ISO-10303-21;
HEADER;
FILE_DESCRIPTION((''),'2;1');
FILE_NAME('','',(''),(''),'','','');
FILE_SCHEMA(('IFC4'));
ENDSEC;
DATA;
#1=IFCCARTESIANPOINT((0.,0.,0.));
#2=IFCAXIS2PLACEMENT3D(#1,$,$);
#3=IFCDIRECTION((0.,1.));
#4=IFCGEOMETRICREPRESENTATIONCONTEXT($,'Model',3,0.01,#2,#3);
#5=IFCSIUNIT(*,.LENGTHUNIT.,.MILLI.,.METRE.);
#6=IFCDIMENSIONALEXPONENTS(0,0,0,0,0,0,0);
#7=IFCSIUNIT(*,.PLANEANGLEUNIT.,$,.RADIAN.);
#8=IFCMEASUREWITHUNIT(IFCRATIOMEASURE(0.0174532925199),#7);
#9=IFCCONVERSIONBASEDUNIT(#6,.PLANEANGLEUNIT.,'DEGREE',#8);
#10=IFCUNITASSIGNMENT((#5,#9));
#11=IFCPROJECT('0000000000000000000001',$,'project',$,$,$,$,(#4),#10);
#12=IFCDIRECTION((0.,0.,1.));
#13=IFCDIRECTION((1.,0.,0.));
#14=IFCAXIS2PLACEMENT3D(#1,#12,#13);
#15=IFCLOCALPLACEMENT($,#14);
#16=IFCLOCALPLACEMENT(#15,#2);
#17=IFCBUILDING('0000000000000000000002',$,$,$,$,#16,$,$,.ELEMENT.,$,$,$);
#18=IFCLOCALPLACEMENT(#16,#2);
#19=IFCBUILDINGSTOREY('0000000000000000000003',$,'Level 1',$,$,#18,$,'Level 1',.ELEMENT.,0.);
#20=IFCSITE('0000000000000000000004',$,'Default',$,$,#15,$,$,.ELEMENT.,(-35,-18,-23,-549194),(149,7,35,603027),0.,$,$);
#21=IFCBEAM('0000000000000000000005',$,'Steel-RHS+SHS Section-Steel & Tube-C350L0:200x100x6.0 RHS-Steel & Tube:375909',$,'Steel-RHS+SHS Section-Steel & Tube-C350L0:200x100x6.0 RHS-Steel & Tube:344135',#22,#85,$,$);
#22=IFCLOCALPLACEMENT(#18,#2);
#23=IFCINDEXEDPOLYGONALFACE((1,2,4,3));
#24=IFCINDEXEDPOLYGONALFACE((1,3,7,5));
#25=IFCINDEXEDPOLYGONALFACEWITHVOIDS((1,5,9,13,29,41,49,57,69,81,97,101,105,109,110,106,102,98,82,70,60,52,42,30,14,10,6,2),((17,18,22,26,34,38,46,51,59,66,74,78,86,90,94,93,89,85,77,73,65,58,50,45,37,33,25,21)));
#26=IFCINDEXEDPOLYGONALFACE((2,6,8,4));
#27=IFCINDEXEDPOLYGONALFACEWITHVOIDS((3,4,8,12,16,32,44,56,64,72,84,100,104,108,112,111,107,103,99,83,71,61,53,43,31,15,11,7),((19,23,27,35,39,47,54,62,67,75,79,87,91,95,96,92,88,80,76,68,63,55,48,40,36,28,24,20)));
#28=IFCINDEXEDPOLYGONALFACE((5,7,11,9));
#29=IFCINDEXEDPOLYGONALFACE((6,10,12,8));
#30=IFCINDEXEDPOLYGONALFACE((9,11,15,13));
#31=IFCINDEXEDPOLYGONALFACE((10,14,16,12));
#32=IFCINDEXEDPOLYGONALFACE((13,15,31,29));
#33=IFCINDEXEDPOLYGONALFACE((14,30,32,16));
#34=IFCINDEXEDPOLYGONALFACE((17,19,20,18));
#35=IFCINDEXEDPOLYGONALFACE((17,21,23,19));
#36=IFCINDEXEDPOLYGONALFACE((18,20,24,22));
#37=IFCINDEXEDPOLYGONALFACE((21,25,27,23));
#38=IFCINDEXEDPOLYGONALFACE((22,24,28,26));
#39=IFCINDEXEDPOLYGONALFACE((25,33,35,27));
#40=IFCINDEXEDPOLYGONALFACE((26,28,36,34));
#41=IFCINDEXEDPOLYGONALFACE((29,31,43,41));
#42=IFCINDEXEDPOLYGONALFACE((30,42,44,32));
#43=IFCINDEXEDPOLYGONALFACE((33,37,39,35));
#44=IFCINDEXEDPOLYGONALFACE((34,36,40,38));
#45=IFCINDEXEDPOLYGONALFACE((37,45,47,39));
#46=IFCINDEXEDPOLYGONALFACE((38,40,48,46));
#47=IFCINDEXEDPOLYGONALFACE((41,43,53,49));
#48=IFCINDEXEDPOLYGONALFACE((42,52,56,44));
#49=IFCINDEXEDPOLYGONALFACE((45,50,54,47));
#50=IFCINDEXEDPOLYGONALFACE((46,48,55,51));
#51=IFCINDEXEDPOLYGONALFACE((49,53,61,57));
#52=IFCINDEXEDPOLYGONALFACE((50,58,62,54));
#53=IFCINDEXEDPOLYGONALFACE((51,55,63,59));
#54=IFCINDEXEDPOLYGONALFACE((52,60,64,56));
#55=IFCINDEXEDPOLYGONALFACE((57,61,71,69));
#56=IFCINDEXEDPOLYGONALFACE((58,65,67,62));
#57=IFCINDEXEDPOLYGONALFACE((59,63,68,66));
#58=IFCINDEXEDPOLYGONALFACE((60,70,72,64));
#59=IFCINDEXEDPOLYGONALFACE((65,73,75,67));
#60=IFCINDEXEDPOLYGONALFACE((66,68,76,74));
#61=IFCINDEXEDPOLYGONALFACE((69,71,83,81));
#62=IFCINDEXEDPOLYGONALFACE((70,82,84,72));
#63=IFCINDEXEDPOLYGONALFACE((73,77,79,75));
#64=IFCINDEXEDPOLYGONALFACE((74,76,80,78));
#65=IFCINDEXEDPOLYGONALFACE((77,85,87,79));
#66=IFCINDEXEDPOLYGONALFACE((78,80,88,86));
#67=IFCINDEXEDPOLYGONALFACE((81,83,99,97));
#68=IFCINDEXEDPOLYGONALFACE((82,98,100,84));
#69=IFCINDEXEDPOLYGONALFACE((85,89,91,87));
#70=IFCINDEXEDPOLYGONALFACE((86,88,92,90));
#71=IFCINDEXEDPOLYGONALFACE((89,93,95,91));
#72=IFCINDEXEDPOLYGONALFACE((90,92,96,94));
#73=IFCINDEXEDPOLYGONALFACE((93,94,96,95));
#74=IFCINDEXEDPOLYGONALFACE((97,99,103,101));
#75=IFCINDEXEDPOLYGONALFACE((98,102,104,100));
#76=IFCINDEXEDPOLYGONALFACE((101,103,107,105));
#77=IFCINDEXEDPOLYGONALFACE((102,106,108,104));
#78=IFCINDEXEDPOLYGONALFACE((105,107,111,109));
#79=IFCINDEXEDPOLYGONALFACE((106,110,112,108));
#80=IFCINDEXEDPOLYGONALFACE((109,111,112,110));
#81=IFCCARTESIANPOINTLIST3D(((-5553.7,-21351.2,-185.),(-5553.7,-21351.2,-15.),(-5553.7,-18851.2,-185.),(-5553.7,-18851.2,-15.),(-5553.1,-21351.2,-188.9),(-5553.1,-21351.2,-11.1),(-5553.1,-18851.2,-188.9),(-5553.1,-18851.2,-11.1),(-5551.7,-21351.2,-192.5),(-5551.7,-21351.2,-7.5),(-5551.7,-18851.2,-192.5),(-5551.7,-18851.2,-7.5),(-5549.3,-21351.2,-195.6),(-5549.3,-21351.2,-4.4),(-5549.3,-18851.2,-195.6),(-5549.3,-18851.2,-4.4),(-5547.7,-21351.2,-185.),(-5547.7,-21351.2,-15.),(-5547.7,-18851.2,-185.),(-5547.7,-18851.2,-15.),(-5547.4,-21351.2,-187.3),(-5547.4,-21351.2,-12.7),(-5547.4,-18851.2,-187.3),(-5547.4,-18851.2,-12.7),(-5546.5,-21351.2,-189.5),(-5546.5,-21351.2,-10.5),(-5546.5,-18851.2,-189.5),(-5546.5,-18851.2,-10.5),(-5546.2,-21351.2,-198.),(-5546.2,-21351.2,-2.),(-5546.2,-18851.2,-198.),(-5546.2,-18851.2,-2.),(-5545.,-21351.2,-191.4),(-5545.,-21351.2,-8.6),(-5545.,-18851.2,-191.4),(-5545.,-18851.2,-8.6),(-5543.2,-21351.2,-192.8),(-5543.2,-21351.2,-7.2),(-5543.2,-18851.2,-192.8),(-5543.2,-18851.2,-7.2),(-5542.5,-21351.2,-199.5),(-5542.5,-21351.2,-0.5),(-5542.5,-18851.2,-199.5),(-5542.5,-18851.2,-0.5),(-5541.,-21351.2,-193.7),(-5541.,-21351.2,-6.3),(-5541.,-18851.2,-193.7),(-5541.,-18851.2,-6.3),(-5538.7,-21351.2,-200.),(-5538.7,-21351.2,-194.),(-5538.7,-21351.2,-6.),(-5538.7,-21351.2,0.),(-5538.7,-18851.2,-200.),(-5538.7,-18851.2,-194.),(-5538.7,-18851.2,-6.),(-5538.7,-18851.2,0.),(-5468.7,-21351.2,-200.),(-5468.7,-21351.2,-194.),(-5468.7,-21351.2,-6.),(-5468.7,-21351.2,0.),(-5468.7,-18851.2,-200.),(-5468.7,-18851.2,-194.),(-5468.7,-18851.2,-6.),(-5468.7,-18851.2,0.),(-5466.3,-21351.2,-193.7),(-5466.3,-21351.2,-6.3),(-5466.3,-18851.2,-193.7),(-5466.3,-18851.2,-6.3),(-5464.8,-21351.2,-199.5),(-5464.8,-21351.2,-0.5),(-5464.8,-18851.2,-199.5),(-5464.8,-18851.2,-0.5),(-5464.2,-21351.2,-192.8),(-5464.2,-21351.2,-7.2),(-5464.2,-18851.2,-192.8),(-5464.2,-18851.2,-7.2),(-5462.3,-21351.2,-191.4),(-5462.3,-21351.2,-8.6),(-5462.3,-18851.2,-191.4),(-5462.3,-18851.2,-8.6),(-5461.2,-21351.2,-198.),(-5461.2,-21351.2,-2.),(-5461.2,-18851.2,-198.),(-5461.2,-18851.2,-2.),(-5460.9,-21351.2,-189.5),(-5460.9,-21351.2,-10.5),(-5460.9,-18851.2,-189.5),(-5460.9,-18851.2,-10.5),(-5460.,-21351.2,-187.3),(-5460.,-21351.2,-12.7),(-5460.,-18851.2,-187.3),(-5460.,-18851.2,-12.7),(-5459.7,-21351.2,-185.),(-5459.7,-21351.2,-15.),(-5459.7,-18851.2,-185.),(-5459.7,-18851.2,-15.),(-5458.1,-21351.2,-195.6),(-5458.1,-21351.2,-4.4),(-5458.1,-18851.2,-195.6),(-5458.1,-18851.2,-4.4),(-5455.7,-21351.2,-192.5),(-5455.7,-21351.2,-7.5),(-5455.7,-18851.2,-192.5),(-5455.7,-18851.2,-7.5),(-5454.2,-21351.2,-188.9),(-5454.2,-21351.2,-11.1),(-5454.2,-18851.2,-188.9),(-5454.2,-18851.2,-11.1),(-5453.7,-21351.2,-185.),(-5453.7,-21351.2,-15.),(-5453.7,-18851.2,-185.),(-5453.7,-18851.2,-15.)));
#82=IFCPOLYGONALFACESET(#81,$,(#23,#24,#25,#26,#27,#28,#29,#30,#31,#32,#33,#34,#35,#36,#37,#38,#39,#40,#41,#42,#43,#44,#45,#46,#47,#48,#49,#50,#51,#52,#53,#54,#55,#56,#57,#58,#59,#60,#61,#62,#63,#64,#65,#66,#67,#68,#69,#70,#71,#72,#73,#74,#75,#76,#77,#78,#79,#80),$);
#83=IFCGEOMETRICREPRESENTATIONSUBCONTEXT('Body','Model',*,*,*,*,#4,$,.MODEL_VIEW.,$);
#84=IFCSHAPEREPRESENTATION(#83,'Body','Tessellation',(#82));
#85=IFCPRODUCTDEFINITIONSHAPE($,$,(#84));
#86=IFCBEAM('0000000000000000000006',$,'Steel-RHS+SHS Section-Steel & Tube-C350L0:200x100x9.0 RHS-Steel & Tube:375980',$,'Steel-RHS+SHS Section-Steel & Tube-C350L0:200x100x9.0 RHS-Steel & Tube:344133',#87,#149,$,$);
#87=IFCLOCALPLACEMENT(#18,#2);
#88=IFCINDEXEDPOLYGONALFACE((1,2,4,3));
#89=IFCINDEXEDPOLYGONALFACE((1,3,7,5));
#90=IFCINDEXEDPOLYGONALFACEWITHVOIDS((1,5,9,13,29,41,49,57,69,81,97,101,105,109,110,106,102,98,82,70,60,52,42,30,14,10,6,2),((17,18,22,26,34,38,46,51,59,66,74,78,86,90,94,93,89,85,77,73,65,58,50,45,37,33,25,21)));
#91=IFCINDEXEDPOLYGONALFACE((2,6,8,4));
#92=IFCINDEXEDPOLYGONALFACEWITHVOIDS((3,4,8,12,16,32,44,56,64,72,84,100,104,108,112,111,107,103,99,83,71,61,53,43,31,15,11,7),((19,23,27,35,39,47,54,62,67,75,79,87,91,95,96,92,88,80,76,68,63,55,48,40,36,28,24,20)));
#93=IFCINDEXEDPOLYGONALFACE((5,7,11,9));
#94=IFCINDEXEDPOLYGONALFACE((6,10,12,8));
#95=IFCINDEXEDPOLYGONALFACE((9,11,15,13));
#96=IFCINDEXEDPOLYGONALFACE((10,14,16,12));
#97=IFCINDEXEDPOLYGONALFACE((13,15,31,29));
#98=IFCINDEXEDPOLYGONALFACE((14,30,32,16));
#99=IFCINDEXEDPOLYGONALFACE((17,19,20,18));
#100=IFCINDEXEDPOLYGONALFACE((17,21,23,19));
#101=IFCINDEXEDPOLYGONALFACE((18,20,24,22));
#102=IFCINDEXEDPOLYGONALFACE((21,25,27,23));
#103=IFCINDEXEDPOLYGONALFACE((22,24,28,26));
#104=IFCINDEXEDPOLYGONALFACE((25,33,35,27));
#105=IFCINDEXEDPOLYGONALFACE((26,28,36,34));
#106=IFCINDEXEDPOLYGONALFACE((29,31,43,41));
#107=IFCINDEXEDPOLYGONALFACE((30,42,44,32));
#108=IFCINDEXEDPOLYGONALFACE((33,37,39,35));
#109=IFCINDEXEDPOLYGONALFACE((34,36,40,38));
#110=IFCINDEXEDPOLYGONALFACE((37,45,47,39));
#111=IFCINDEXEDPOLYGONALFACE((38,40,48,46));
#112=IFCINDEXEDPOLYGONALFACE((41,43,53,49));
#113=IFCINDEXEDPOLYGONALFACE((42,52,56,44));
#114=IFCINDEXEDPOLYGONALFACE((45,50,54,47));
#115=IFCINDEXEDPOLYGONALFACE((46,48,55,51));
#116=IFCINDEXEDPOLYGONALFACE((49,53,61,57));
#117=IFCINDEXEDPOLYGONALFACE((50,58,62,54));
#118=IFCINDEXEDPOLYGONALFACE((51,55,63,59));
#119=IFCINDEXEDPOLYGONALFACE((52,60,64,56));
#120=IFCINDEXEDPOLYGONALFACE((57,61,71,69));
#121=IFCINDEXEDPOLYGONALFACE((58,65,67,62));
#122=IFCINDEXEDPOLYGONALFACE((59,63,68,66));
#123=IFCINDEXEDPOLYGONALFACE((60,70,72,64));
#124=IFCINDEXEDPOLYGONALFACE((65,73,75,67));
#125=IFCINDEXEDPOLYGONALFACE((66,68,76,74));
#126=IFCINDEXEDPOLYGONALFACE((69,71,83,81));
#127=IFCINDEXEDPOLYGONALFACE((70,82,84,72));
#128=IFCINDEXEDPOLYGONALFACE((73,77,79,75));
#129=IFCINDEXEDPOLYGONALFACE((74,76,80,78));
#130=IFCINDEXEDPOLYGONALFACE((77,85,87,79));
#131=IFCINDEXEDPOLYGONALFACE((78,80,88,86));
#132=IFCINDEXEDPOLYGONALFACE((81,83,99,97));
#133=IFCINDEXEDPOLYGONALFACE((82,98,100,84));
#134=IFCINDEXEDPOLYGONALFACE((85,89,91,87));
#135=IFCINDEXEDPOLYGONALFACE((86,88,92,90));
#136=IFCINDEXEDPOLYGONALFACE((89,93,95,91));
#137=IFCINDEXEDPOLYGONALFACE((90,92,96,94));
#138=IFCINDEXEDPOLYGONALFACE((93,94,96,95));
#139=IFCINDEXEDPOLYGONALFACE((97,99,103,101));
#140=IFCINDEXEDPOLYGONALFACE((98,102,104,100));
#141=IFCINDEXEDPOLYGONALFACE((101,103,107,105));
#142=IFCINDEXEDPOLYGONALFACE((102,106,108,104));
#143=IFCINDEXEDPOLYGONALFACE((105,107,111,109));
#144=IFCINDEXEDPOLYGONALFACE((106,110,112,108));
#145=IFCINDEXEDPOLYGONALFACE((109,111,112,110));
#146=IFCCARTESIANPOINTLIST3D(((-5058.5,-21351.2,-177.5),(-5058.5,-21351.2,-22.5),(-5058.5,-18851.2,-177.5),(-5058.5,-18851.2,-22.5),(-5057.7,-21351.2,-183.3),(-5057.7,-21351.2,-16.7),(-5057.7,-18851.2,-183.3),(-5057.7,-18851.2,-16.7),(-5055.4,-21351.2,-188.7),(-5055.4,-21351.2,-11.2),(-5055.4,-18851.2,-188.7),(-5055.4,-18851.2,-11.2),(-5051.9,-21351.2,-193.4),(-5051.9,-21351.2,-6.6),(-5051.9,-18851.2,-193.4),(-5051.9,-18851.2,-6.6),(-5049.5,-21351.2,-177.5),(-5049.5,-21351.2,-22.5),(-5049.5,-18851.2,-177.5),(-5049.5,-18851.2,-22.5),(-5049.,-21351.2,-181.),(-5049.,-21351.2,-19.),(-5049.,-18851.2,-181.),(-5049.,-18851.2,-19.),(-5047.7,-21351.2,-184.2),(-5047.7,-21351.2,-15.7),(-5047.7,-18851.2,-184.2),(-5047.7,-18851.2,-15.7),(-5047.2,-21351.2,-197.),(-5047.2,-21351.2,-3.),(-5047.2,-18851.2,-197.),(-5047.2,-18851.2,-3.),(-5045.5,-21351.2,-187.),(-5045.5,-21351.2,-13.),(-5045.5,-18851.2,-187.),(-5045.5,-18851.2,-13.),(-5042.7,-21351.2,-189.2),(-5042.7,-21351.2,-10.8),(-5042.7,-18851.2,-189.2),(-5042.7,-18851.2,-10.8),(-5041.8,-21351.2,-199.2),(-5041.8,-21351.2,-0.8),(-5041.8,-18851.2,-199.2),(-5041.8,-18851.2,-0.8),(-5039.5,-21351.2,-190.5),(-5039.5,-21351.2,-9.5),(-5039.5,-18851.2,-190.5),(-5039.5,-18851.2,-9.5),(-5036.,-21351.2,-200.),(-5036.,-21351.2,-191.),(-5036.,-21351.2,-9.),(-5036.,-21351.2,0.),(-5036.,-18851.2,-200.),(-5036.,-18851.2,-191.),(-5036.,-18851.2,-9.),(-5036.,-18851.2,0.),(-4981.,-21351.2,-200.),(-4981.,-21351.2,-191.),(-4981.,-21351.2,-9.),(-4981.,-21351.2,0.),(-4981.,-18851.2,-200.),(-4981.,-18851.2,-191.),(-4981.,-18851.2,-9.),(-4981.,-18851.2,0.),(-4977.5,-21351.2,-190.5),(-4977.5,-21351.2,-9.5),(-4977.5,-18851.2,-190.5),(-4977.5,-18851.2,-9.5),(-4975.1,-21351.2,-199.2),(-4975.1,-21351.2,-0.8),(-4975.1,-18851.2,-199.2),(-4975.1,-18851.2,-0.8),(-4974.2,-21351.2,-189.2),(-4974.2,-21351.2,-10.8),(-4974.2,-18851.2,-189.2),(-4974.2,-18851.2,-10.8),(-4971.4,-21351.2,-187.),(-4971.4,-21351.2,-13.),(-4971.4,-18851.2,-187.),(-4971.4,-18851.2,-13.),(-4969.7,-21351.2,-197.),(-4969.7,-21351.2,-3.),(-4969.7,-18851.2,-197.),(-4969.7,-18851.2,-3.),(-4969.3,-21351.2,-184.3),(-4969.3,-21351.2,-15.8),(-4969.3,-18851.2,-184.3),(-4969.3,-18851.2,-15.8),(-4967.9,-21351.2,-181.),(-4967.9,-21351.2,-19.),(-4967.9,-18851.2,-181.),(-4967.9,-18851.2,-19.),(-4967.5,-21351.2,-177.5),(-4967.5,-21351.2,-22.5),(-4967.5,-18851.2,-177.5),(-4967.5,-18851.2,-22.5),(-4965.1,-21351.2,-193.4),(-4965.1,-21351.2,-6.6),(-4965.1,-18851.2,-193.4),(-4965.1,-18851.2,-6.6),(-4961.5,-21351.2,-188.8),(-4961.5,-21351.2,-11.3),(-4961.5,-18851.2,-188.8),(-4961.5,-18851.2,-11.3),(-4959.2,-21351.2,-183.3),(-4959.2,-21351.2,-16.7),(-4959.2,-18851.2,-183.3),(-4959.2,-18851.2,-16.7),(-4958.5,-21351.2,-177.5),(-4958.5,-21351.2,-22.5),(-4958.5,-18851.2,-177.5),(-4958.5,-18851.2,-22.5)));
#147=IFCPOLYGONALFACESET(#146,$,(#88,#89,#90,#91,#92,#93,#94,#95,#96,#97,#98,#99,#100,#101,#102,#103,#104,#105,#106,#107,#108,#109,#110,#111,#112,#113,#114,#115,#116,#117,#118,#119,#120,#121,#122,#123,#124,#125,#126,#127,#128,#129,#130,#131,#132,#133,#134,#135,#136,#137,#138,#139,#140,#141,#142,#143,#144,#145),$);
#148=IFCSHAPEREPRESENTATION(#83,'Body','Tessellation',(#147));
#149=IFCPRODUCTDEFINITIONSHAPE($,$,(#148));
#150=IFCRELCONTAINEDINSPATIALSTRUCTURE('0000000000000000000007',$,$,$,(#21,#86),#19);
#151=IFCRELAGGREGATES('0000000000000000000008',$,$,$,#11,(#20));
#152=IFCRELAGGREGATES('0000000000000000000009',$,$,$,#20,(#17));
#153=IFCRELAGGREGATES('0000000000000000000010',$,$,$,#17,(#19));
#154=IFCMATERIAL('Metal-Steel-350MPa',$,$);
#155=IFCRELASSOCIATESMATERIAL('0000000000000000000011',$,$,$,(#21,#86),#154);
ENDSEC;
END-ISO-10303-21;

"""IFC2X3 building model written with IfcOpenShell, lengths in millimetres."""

from ifc_helpers import new_model, entity, si_unit, converted_unit, direction, frame, frame_2d, origin, origin_with_axes, place, context, subcontext, project, spatial, polyline, circle_curve, parameter, trimmed, segment, composite_curve, outline, extrude, material, element, save


model = new_model("IFC2X3")

# Units and contexts
model_context = context("Model", 3, precision=0.01, world=origin(), true_north=direction((0.0, 1.0)))
body_context = subcontext(model_context, "Body", "Model", "MODEL_VIEW")
ifc_project = project(units=[si_unit("LENGTHUNIT", "METRE", prefix="MILLI"), converted_unit("PLANEANGLEUNIT", "DEGREE", entity("IfcRatioMeasure", 0.0174532925199), si_unit("PLANEANGLEUNIT", "RADIAN"), dimensions=[0, 0, 0, 0, 0, 0, 0])], contexts=[model_context])

# Site, building, storey
site_placement = place(None, origin_with_axes())
site = spatial("IfcSite", under=ifc_project, at=site_placement, Name="Default", CompositionType="ELEMENT", RefLatitude=(-35, -18, -23, -549194), RefLongitude=(149, 7, 35, 603027), RefElevation=0.0)
building_placement = place(site_placement, origin())
building = spatial("IfcBuilding", under=site, at=building_placement, CompositionType="ELEMENT")
storey_placement = place(building_placement, origin())
storey = spatial("IfcBuildingStorey", under=building, at=storey_placement, Name="Level 1", LongName="Level 1", CompositionType="ELEMENT", Elevation=0.0)

# Beams
ifc_material = material(Name="Metal-Steel-350MPa")
beam_1_placement = place(storey_placement, frame((-5503.7, -18851.2, 0.0), z_axis=(0.0, 0.0, 1.0), x_axis=(0.0, -1.0, 0.0)))
element("IfcBeam", 1, at=beam_1_placement, inside=storey, material=ifc_material, Name="Steel-RHS+SHS Section-Steel & Tube-C350L0:200x100x6.0 RHS-Steel & Tube:375909", ObjectType="Steel-RHS+SHS Section-Steel & Tube-C350L0:200x100x6.0 RHS-Steel & Tube:344135", context=body_context, shape_type="SweptSolid", body=[
    extrude(outline(composite_curve([segment(trimmed(circle_curve(frame_2d((-35.0, -85.0), x_axis=(1.0, 0.0)), 15.0), [parameter(180.0)], [parameter(270.0)], True, "PARAMETER"), True, "CONTINUOUS"), segment(polyline([(-35.0, -100.0), (35.0, -100.0)]), True, "CONTINUOUS"), segment(trimmed(circle_curve(frame_2d((35.0, -85.0), x_axis=(1.0, 0.0)), 15.0), [parameter(270.0)], [parameter(0.0)], True, "PARAMETER"), True, "CONTINUOUS"), segment(polyline([(50.0, -85.0), (50.0, 85.0)]), True, "CONTINUOUS"), segment(trimmed(circle_curve(frame_2d((35.0, 85.0), x_axis=(1.0, 0.0)), 15.0), [parameter(0.0)], [parameter(90.0)], True, "PARAMETER"), True, "CONTINUOUS"), segment(polyline([(35.0, 100.0), (-35.0, 100.0)]), True, "CONTINUOUS"), segment(trimmed(circle_curve(frame_2d((-35.0, 85.0), x_axis=(1.0, 0.0)), 15.0), [parameter(90.0)], [parameter(180.0)], True, "PARAMETER"), True, "CONTINUOUS"), segment(polyline([(-50.0, 85.0), (-50.0, -85.0)]), True, "CONTINUOUS")], self_intersect=False), holes=[composite_curve([segment(polyline([(35.0, -94.0), (-35.0, -94.0)]), True, "CONTINUOUS"), segment(trimmed(circle_curve(frame_2d((-35.0, -85.0), x_axis=(1.0, 0.0)), 9.0), [parameter(180.0)], [parameter(270.0)], True, "PARAMETER"), False, "CONTINUOUS"), segment(polyline([(-44.0, -85.0), (-44.0, 85.0)]), True, "CONTINUOUS"), segment(trimmed(circle_curve(frame_2d((-35.0, 85.0), x_axis=(1.0, 0.0)), 9.0), [parameter(90.0)], [parameter(180.0)], True, "PARAMETER"), False, "CONTINUOUS"), segment(polyline([(-35.0, 94.0), (35.0, 94.0)]), True, "CONTINUOUS"), segment(trimmed(circle_curve(frame_2d((35.0, 85.0), x_axis=(1.0, 0.0)), 9.0), [parameter(360.0)], [parameter(90.0)], True, "PARAMETER"), False, "CONTINUOUS"), segment(polyline([(44.0, 85.0), (44.0, -85.0)]), True, "CONTINUOUS"), segment(trimmed(circle_curve(frame_2d((35.0, -85.0), x_axis=(1.0, 0.0)), 9.0), [parameter(270.0)], [parameter(360.0)], True, "PARAMETER"), False, "CONTINUOUS")], self_intersect=False)]), frame((0.0, 0.0, -100.0), z_axis=(1.0, 0.0, 0.0), x_axis=(0.0, -1.0, 0.0)), (0.0, 0.0, 1.0), 2500.0),
])
beam_2_placement = place(storey_placement, frame((-5008.5, -18851.2, 0.0), z_axis=(0.0, 0.0, 1.0), x_axis=(0.0, -1.0, 0.0)))
element("IfcBeam", 2, at=beam_2_placement, inside=storey, material=ifc_material, Name="Steel-RHS+SHS Section-Steel & Tube-C350L0:200x100x9.0 RHS-Steel & Tube:375980", ObjectType="Steel-RHS+SHS Section-Steel & Tube-C350L0:200x100x9.0 RHS-Steel & Tube:344133", context=body_context, shape_type="SweptSolid", body=[
    extrude(outline(composite_curve([segment(trimmed(circle_curve(frame_2d((-27.5, -77.5), x_axis=(1.0, 0.0)), 22.5), [parameter(180.0)], [parameter(270.0)], True, "PARAMETER"), True, "CONTINUOUS"), segment(polyline([(-27.5, -100.0), (27.5, -100.0)]), True, "CONTINUOUS"), segment(trimmed(circle_curve(frame_2d((27.5, -77.5), x_axis=(1.0, 0.0)), 22.5), [parameter(270.0)], [parameter(0.0)], True, "PARAMETER"), True, "CONTINUOUS"), segment(polyline([(50.0, -77.5), (50.0, 77.5)]), True, "CONTINUOUS"), segment(trimmed(circle_curve(frame_2d((27.5, 77.5), x_axis=(1.0, 0.0)), 22.5), [parameter(0.0)], [parameter(90.0)], True, "PARAMETER"), True, "CONTINUOUS"), segment(polyline([(27.5, 100.0), (-27.5, 100.0)]), True, "CONTINUOUS"), segment(trimmed(circle_curve(frame_2d((-27.5, 77.5), x_axis=(1.0, 0.0)), 22.5), [parameter(90.0)], [parameter(180.0)], True, "PARAMETER"), True, "CONTINUOUS"), segment(polyline([(-50.0, 77.5), (-50.0, -77.5)]), True, "CONTINUOUS")], self_intersect=False), holes=[composite_curve([segment(polyline([(27.5, -91.0), (-27.5, -91.0)]), True, "CONTINUOUS"), segment(trimmed(circle_curve(frame_2d((-27.5, -77.5), x_axis=(1.0, 0.0)), 13.5), [parameter(180.0)], [parameter(270.0)], True, "PARAMETER"), False, "CONTINUOUS"), segment(polyline([(-41.0, -77.5), (-41.0, 77.5)]), True, "CONTINUOUS"), segment(trimmed(circle_curve(frame_2d((-27.5, 77.5), x_axis=(1.0, 0.0)), 13.5), [parameter(90.0)], [parameter(180.0)], True, "PARAMETER"), False, "CONTINUOUS"), segment(polyline([(-27.5, 91.0), (27.5, 91.0)]), True, "CONTINUOUS"), segment(trimmed(circle_curve(frame_2d((27.5, 77.5), x_axis=(1.0, 0.0)), 13.5), [parameter(360.0)], [parameter(90.0)], True, "PARAMETER"), False, "CONTINUOUS"), segment(polyline([(41.0, 77.5), (41.0, -77.5)]), True, "CONTINUOUS"), segment(trimmed(circle_curve(frame_2d((27.5, -77.5), x_axis=(1.0, 0.0)), 13.5), [parameter(270.0)], [parameter(360.0)], True, "PARAMETER"), False, "CONTINUOUS")], self_intersect=False)]), frame((0.0, 0.0, -100.0), z_axis=(1.0, 0.0, 0.0), x_axis=(0.0, -1.0, 0.0)), (0.0, 0.0, 1.0), 2500.0),
])

save(model, "model.ifc")
